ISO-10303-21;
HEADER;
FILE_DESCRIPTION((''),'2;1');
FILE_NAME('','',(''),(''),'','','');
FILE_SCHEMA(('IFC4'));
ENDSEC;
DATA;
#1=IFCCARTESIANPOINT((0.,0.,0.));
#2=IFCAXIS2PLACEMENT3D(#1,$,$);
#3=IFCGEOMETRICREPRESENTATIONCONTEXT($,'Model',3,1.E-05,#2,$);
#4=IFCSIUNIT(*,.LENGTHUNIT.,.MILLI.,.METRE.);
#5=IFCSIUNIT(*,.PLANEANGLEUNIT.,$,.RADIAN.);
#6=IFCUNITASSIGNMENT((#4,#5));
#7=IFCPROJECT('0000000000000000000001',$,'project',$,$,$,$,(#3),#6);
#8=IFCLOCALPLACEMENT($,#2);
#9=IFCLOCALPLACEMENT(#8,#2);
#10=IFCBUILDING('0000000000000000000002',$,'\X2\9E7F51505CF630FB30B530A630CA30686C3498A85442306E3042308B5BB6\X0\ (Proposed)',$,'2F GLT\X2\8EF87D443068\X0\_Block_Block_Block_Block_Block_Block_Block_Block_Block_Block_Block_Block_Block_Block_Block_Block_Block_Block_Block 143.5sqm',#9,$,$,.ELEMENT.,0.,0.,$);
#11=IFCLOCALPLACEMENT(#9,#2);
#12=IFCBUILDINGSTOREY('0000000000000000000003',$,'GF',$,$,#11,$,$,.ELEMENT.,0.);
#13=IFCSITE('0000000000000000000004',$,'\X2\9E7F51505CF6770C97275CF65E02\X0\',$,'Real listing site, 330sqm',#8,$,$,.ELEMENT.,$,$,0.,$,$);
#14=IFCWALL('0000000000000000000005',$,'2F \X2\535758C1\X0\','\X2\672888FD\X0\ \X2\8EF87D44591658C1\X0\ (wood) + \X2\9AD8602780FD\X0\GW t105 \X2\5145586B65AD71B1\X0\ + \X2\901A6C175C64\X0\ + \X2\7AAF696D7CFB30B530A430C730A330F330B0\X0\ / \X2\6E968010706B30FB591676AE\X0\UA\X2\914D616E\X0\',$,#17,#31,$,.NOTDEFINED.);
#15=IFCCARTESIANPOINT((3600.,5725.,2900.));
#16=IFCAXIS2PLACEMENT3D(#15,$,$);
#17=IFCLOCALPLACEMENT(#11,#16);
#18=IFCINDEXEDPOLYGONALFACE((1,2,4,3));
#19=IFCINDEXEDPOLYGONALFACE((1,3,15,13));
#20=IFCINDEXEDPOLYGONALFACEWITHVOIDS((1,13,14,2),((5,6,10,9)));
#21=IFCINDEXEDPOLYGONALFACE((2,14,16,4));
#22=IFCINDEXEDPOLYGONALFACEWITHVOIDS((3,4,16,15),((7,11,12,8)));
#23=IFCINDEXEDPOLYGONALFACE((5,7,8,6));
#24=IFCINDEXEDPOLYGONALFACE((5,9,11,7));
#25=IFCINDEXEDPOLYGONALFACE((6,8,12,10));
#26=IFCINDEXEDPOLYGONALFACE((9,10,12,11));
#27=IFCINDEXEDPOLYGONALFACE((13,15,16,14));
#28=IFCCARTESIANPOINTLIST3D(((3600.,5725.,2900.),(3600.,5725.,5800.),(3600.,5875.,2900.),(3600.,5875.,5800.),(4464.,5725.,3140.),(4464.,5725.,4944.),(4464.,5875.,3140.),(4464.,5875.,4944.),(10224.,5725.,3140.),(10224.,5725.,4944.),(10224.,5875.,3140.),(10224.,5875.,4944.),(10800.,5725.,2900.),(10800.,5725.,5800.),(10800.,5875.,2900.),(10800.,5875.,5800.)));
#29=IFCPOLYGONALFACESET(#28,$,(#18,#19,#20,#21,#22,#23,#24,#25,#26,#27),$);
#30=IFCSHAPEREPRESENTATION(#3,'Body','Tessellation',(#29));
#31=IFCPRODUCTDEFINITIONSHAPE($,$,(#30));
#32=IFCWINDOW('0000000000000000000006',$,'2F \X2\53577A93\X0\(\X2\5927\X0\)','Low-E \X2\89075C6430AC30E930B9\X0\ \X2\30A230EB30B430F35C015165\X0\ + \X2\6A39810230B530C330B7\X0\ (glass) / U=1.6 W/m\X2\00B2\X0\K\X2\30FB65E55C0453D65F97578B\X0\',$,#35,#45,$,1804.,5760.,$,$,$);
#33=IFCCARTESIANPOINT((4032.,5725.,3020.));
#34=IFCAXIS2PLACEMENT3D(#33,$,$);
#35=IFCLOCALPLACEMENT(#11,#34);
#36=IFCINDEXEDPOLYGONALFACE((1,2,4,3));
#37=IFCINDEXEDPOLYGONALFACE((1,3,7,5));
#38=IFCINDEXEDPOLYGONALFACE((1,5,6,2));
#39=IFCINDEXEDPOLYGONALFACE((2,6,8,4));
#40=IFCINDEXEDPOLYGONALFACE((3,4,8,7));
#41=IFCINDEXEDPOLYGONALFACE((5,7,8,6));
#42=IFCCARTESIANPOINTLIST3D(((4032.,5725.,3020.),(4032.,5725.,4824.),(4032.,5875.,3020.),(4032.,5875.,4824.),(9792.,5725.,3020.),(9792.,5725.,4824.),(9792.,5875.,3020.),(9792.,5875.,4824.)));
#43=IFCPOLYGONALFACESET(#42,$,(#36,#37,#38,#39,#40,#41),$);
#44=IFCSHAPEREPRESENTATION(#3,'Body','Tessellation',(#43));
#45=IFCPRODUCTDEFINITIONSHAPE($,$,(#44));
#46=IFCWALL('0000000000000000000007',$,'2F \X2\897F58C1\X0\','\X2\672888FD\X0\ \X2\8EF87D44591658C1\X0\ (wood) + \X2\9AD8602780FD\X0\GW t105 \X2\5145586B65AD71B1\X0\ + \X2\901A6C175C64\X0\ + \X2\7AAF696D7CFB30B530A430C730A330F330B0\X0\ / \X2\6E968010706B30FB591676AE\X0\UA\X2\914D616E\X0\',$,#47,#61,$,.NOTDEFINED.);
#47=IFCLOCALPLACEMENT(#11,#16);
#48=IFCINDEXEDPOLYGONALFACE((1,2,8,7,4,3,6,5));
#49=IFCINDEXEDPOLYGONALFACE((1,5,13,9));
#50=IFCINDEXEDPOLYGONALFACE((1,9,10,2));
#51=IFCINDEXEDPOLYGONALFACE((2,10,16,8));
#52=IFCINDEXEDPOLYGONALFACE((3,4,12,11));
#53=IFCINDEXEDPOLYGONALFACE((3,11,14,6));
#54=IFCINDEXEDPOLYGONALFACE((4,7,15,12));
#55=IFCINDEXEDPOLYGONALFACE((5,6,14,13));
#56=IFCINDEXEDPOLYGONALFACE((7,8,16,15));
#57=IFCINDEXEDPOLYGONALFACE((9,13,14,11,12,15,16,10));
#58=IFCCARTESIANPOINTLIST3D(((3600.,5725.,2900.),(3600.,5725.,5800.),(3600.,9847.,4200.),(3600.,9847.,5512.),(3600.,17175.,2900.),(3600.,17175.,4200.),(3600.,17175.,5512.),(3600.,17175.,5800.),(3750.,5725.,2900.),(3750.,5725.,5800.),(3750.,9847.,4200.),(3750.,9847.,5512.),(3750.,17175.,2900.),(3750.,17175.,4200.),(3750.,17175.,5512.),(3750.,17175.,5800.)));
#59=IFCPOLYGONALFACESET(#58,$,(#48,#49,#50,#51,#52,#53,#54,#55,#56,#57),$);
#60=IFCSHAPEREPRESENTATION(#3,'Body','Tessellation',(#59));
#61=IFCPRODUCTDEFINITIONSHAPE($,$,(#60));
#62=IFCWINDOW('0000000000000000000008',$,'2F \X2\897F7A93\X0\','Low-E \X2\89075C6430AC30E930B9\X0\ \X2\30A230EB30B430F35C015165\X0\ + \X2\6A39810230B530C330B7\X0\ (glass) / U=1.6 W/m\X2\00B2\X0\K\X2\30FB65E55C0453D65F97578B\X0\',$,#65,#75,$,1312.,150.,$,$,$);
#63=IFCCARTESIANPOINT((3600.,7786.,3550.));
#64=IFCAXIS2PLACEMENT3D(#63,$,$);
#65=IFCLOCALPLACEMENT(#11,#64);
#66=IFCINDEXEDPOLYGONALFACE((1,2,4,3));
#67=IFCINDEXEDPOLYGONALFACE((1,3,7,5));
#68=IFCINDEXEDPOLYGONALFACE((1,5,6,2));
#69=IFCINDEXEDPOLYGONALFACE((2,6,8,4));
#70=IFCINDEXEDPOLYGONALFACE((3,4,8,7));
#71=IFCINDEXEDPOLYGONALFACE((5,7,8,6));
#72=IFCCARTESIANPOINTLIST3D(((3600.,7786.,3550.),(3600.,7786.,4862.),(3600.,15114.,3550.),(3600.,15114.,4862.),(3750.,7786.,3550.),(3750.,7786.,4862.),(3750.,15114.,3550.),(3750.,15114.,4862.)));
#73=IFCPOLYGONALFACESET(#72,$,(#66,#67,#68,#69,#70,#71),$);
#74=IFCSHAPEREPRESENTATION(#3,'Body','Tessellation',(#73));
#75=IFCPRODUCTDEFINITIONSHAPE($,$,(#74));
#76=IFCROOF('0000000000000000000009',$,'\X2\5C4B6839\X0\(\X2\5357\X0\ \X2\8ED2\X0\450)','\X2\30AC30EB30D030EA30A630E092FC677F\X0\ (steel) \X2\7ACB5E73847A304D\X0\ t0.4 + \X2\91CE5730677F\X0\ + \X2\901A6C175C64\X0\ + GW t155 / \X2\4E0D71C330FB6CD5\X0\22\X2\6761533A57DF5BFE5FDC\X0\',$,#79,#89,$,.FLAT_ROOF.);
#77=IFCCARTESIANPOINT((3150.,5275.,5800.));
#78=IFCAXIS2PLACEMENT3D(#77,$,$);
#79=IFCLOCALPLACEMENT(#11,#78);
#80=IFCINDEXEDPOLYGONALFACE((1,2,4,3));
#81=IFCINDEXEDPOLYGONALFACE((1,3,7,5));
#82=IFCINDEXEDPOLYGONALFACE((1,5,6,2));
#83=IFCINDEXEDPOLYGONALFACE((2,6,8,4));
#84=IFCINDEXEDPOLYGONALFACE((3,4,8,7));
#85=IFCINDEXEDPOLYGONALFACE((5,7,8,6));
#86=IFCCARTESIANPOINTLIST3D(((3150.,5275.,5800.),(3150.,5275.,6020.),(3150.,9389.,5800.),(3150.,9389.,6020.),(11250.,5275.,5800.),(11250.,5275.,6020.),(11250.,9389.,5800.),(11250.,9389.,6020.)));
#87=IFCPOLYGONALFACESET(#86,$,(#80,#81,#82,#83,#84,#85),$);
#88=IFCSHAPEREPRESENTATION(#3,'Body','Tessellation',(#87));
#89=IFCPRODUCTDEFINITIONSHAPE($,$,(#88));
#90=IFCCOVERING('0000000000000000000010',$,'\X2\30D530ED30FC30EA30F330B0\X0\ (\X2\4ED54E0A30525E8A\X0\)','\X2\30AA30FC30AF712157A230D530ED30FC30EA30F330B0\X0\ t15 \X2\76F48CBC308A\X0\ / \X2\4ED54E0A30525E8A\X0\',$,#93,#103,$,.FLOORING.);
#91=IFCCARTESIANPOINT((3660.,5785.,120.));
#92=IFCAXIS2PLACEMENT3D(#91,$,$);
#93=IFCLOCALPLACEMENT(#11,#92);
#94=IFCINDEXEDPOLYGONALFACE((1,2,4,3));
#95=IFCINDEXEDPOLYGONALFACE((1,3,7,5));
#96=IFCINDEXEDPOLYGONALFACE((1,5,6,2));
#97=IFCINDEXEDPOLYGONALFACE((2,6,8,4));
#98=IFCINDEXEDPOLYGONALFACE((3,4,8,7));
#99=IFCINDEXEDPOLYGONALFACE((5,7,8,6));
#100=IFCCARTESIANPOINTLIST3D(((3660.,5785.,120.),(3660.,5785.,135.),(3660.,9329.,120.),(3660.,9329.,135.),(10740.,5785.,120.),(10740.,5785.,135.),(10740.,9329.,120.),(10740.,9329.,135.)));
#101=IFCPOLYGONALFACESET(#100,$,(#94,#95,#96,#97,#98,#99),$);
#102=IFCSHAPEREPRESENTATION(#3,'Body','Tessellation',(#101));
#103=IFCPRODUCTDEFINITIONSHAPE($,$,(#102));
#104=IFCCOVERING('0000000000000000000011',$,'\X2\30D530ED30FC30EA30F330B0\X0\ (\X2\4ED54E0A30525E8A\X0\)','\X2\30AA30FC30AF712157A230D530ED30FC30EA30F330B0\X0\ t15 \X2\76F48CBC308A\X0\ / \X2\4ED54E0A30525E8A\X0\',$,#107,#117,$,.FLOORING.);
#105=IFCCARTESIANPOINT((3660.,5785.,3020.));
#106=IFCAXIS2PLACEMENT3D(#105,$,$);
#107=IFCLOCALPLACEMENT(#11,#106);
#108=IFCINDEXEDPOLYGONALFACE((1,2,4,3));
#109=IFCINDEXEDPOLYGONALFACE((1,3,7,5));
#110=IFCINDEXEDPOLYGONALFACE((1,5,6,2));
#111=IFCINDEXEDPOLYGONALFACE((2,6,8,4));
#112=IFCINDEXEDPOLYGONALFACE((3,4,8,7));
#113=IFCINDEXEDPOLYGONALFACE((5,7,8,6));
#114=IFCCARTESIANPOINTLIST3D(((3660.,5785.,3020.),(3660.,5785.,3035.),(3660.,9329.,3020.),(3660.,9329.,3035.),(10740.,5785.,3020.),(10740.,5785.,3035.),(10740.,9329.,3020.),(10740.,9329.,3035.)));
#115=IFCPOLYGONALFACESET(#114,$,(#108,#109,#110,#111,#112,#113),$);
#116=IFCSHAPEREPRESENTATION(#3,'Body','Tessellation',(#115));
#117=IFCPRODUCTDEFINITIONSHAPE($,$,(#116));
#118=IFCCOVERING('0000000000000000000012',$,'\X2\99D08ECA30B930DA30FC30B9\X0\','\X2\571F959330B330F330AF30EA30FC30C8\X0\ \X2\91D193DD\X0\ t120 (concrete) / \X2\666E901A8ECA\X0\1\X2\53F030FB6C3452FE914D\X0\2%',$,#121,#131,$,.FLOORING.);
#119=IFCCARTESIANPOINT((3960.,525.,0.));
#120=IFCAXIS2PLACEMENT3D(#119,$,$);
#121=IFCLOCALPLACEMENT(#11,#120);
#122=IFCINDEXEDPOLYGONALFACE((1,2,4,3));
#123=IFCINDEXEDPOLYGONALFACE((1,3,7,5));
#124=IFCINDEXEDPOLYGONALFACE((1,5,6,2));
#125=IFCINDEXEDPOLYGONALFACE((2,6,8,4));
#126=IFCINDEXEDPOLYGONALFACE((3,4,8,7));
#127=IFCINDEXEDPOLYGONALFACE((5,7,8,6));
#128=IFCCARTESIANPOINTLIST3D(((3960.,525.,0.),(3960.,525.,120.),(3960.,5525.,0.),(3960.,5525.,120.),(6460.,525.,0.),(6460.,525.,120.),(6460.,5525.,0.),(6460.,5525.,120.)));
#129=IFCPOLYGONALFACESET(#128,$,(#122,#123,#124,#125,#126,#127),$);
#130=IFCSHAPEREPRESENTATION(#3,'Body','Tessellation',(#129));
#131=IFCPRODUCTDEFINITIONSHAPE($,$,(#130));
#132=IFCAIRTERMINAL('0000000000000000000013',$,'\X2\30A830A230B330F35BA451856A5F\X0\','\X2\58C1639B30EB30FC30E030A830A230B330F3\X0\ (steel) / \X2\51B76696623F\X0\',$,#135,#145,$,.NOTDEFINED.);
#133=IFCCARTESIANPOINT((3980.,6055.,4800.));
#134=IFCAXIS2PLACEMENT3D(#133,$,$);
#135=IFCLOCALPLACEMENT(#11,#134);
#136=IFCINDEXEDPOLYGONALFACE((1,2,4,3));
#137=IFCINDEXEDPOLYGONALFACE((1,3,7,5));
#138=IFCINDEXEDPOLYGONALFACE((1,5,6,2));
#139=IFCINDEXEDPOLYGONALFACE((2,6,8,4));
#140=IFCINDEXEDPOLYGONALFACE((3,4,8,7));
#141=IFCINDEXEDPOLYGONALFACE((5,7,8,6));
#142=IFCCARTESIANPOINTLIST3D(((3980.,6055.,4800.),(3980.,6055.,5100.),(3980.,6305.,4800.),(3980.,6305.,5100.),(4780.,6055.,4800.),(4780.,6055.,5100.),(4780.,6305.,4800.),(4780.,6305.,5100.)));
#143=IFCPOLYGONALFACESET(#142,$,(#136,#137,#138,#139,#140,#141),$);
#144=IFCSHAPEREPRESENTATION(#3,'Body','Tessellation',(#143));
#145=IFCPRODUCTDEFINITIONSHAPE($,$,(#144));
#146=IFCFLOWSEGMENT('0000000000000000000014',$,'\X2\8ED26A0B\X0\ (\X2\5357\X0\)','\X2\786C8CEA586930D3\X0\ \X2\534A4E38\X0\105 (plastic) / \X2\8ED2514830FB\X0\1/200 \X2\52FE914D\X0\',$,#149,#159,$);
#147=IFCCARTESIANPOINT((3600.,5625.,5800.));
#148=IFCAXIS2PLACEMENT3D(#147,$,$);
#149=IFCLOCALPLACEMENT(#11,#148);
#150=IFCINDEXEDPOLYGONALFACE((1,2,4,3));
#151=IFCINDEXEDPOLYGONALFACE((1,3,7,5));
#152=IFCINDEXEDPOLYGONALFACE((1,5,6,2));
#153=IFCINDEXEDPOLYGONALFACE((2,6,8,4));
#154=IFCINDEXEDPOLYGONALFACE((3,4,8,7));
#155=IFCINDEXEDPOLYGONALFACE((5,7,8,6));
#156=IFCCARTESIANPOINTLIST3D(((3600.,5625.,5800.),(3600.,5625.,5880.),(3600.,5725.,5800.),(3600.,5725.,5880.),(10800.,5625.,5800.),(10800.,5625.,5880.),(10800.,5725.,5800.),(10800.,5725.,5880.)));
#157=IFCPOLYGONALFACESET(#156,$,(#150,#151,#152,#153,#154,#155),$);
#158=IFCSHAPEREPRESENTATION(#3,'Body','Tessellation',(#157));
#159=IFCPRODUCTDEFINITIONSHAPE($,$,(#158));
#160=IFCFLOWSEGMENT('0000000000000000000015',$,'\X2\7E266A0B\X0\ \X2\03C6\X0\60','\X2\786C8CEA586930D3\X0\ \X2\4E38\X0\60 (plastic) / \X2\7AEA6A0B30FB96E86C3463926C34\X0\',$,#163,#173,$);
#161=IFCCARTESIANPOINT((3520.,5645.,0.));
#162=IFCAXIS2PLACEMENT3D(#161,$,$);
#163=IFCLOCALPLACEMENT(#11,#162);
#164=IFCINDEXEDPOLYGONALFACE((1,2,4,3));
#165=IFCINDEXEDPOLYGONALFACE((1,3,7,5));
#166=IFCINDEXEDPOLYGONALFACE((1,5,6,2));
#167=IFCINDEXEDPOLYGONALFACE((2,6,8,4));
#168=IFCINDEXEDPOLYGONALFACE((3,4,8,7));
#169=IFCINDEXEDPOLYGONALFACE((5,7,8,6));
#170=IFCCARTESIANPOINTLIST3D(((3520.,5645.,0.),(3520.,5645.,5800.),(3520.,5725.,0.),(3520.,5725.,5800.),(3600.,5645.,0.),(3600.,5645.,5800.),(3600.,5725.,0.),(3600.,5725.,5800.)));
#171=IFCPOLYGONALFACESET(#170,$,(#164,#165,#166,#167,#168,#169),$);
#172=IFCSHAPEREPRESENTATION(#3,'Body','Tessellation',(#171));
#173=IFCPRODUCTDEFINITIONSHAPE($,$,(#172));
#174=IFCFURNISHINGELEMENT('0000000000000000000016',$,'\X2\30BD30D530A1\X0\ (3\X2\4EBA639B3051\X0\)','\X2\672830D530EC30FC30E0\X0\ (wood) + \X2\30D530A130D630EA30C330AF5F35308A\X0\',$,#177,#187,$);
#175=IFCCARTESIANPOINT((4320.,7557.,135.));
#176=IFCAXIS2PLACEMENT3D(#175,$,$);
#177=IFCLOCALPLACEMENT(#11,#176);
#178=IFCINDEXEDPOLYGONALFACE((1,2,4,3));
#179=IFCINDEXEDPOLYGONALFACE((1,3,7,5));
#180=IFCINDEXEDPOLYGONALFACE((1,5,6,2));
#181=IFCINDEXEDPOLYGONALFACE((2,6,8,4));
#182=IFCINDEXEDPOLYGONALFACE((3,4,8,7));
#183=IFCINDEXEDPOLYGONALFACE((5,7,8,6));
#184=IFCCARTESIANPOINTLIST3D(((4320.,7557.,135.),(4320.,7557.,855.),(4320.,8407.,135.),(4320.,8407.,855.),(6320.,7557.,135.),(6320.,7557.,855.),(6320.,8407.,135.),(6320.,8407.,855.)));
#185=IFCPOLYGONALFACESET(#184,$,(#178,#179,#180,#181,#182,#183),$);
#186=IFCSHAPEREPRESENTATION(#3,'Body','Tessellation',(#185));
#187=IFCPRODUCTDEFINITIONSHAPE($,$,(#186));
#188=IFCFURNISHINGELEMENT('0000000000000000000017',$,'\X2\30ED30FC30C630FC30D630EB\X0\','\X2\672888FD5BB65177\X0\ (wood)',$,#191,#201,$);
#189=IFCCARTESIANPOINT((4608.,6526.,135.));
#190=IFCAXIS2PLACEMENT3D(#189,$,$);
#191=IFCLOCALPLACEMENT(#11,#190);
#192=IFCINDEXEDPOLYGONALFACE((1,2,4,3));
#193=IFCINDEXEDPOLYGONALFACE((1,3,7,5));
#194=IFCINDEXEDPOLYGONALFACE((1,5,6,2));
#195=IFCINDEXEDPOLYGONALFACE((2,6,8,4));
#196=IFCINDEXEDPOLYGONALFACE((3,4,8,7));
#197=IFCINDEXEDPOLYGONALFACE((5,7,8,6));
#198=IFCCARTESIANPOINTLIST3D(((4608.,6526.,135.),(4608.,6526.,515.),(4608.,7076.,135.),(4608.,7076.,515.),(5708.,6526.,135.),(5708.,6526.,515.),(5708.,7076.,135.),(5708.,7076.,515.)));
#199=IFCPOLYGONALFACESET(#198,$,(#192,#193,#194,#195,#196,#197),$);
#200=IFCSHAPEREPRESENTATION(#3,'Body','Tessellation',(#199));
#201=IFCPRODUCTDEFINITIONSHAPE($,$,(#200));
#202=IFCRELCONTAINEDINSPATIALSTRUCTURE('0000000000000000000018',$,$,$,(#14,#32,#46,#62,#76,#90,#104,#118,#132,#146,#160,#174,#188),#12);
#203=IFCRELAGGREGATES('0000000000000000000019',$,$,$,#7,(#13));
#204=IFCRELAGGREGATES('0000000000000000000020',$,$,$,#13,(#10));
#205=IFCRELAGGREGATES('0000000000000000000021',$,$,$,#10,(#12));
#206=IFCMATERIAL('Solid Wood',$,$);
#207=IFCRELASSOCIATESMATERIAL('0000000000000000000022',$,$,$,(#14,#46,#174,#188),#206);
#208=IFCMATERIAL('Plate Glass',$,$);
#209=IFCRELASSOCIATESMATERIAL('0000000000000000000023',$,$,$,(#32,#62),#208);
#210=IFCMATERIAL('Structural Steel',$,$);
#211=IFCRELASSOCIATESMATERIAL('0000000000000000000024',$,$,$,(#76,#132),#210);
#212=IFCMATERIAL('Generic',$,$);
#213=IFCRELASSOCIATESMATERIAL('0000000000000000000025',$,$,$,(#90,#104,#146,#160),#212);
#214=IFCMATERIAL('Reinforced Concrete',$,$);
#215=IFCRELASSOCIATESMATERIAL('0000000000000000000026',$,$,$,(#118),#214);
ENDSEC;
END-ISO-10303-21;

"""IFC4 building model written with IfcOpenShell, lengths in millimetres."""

from ifc_helpers import new_model, si_unit, frame, frame_2d, origin, place, context, project, spatial, rectangle, extrude, material, element, fill, save


model = new_model("IFC4")

# Units and contexts
model_context = context("Model", 3, precision=1e-05, world=origin())
ifc_project = project(units=[si_unit("LENGTHUNIT", "METRE", prefix="MILLI"), si_unit("PLANEANGLEUNIT", "RADIAN")], contexts=[model_context])

# Site, building, storey
site_placement = place(None, origin())
site = spatial("IfcSite", under=ifc_project, at=site_placement, Name="鹿児島県霧島市", ObjectType="Real listing site, 330sqm", CompositionType="ELEMENT", RefElevation=0.0)
building_placement = place(site_placement, origin())
building = spatial("IfcBuilding", under=site, at=building_placement, Name="鹿児島・サウナと水風呂のある家 (Proposed)", ObjectType="2F GLT軸組と_Block_Block_Block_Block_Block_Block_Block_Block_Block_Block_Block_Block_Block_Block_Block_Block_Block_Block_Block 143.5sqm", CompositionType="ELEMENT", ElevationOfRefHeight=0.0, ElevationOfTerrain=0.0)
storey_placement = place(building_placement, origin())
storey = spatial("IfcBuildingStorey", under=building, at=storey_placement, Name="GF", CompositionType="ELEMENT", Elevation=0.0)

# Shared definitions
ifc_material_1 = material(Name="Solid Wood")

# Shared definitions
ifc_material_2 = material(Name="Reinforced Concrete")

# Shared definitions
ifc_material_3 = material(Name="Plate Glass")

# Walls, openings, windows
wall_1_placement = place(storey_placement, frame((3600.0, 5725.0, 2900.0)))
wall_1 = element("IfcWall", 1, at=wall_1_placement, inside=storey, material=ifc_material_1, Name="2F 南壁", Description="木製 軸組外壁 (wood) + 高性能GW t105 充填断熱 + 通気層 + 窯業系サイディング / 準耐火・外皮UA配慮", PredefinedType="NOTDEFINED", context=model_context, shape_type="SweptSolid", body=[
    extrude(rectangle(XDim=7200.0, YDim=150.0, at=frame_2d((3600.0, 75.0))), frame((3600.0, 5725.0, 2900.0)), (0.0, 0.0, 1.0), 2900.0),
])
opening_1_placement = place(storey_placement, frame((4032.0, 5725.0, 3020.0)))
opening_1 = element("IfcOpeningElement", 2, at=opening_1_placement, cuts=wall_1, PredefinedType="NOTDEFINED", context=model_context, shape_type="SweptSolid", body=[
    extrude(rectangle(XDim=5760.0, YDim=150.0, at=frame_2d((2880.0, 75.0))), frame((4032.0, 5725.0, 3020.0)), (0.0, 0.0, 1.0), 1804.0),
])
window_1_placement = place(storey_placement, frame((4032.0, 5725.0, 3020.0)))
window_1 = element("IfcWindow", 3, at=window_1_placement, inside=storey, material=ifc_material_3, Name="2F 南窓(大)", Description="Low-E 複層ガラス アルゴン封入 + 樹脂サッシ (glass) / U=1.6 W/m²K・日射取得型", OverallHeight=1804.0, OverallWidth=5760.0, context=model_context, shape_type="SweptSolid", body=[
    extrude(rectangle(XDim=5760.0, YDim=150.0, at=frame_2d((2880.0, 75.0))), frame((4032.0, 5725.0, 3020.0)), (0.0, 0.0, 1.0), 1804.0),
])
fill(opening_1, window_1)
wall_2_placement = place(storey_placement, frame((3600.0, 5725.0, 2900.0)))
wall_2 = element("IfcWall", 4, at=wall_2_placement, inside=storey, material=ifc_material_1, Name="2F 西壁", Description="木製 軸組外壁 (wood) + 高性能GW t105 充填断熱 + 通気層 + 窯業系サイディング / 準耐火・外皮UA配慮", PredefinedType="NOTDEFINED", context=model_context, shape_type="SweptSolid", body=[
    extrude(rectangle(XDim=150.0, YDim=11450.0, at=frame_2d((75.0, 5725.0))), frame((3600.0, 5725.0, 2900.0)), (0.0, 0.0, 1.0), 2900.0),
])
opening_2_placement = place(storey_placement, frame((3600.0, 7786.0, 3550.0)))
opening_2 = element("IfcOpeningElement", 5, at=opening_2_placement, cuts=wall_2, PredefinedType="NOTDEFINED", context=model_context, shape_type="SweptSolid", body=[
    extrude(rectangle(XDim=150.0, YDim=7328.0, at=frame_2d((75.0, 3664.0))), frame((3600.0, 7786.0, 3550.0)), (0.0, 0.0, 1.0), 1312.0),
])
window_2_placement = place(storey_placement, frame((3600.0, 7786.0, 3550.0)))
window_2 = element("IfcWindow", 6, at=window_2_placement, inside=storey, material=ifc_material_3, Name="2F 西窓", Description="Low-E 複層ガラス アルゴン封入 + 樹脂サッシ (glass) / U=1.6 W/m²K・日射取得型", OverallHeight=1312.0, OverallWidth=150.0, context=model_context, shape_type="SweptSolid", body=[
    extrude(rectangle(XDim=150.0, YDim=7328.0, at=frame_2d((75.0, 3664.0))), frame((3600.0, 7786.0, 3550.0)), (0.0, 0.0, 1.0), 1312.0),
])
fill(opening_2, window_2)

# Roof
ifc_material_4 = material(Name="Structural Steel")
for number, where, name in (
    (7, (3150.0, 5275.0, 5800.0), "屋根(南 軒450)"),
):
    element("IfcRoof", number, at=place(storey_placement, frame(where)), inside=storey, material=ifc_material_4, Name=name, Description="ガルバリウム鋼板 (steel) 立平葺き t0.4 + 野地板 + 通気層 + GW t155 / 不燃・法22条区域対応", PredefinedType="FLAT_ROOF", context=model_context, shape_type="SweptSolid", body=[
        extrude(rectangle(XDim=8100.0, YDim=4114.0, at=frame_2d((4050.0, 2057.0))), frame((3150.0, 5275.0, 5800.0)), (0.0, 0.0, 1.0), 220.0),
    ])

# Coverings
ifc_material_5 = material(Name="Generic")
covering_1_placement = place(storey_placement, frame((3660.0, 5785.0, 120.0)))
element("IfcCovering", 8, at=covering_1_placement, inside=storey, material=ifc_material_5, Name="フローリング (仕上げ床)", Description="オーク無垢フローリング t15 直貼り / 仕上げ床", PredefinedType="FLOORING", context=model_context, shape_type="SweptSolid", body=[
    extrude(rectangle(XDim=7080.0, YDim=3544.0, at=frame_2d((3540.0, 1772.0))), frame((3660.0, 5785.0, 120.0)), (0.0, 0.0, 1.0), 15.0),
])
covering_2_placement = place(storey_placement, frame((3660.0, 5785.0, 3020.0)))
element("IfcCovering", 9, at=covering_2_placement, inside=storey, material=ifc_material_5, Name="フローリング (仕上げ床)", Description="オーク無垢フローリング t15 直貼り / 仕上げ床", PredefinedType="FLOORING", context=model_context, shape_type="SweptSolid", body=[
    extrude(rectangle(XDim=7080.0, YDim=3544.0, at=frame_2d((3540.0, 1772.0))), frame((3660.0, 5785.0, 3020.0)), (0.0, 0.0, 1.0), 15.0),
])
covering_3_placement = place(storey_placement, frame((3960.0, 525.0, 0.0)))
element("IfcCovering", 10, at=covering_3_placement, inside=storey, material=ifc_material_2, Name="駐車スペース", Description="土間コンクリート 金鏝 t120 (concrete) / 普通車1台・水勾配2%", PredefinedType="FLOORING", context=model_context, shape_type="SweptSolid", body=[
    extrude(rectangle(XDim=2500.0, YDim=5000.0, at=frame_2d((1250.0, 2500.0))), frame((3960.0, 525.0, 0.0)), (0.0, 0.0, 1.0), 120.0),
])

# Air terminal
air_terminal_placement = place(storey_placement, frame((3980.0, 6055.0, 4800.0)))
element("IfcAirTerminal", 11, at=air_terminal_placement, inside=storey, material=ifc_material_4, Name="エアコン室内機", Description="壁掛ルームエアコン (steel) / 冷暖房", PredefinedType="NOTDEFINED", context=model_context, shape_type="SweptSolid", body=[
    extrude(rectangle(XDim=800.0, YDim=250.0, at=frame_2d((400.0, 125.0))), frame((3980.0, 6055.0, 4800.0)), (0.0, 0.0, 1.0), 300.0),
])

# Flow segments
flow_segment_1_placement = place(storey_placement, frame((3600.0, 5625.0, 5800.0)))
element("IfcFlowSegment", 12, at=flow_segment_1_placement, inside=storey, material=ifc_material_5, Name="軒樋 (南)", Description="硬質塩ビ 半丸105 (plastic) / 軒先・1/200 勾配", context=model_context, shape_type="SweptSolid", body=[
    extrude(rectangle(XDim=7200.0, YDim=100.0, at=frame_2d((3600.0, 50.0))), frame((3600.0, 5625.0, 5800.0)), (0.0, 0.0, 1.0), 80.0),
])
flow_segment_2_placement = place(storey_placement, frame((3520.0, 5645.0, 0.0)))
element("IfcFlowSegment", 13, at=flow_segment_2_placement, inside=storey, material=ifc_material_5, Name="縦樋 φ60", Description="硬質塩ビ 丸60 (plastic) / 竪樋・雨水排水", context=model_context, shape_type="SweptSolid", body=[
    extrude(rectangle(XDim=80.0, YDim=80.0, at=frame_2d((40.0, 40.0))), frame((3520.0, 5645.0, 0.0)), (0.0, 0.0, 1.0), 5800.0),
])

# Furnishing elements
furnishing_1_placement = place(storey_placement, frame((4320.0, 7557.0, 135.0)))
element("IfcFurnishingElement", 14, at=furnishing_1_placement, inside=storey, material=ifc_material_1, Name="ソファ (3人掛け)", Description="木フレーム (wood) + ファブリック張り", context=model_context, shape_type="SweptSolid", body=[
    extrude(rectangle(XDim=2000.0, YDim=850.0, at=frame_2d((1000.0, 425.0))), frame((4320.0, 7557.0, 135.0)), (0.0, 0.0, 1.0), 720.0),
])
furnishing_2_placement = place(storey_placement, frame((4608.0, 6526.0, 135.0)))
element("IfcFurnishingElement", 15, at=furnishing_2_placement, inside=storey, material=ifc_material_1, Name="ローテーブル", Description="木製家具 (wood)", context=model_context, shape_type="SweptSolid", body=[
    extrude(rectangle(XDim=1100.0, YDim=550.0, at=frame_2d((550.0, 275.0))), frame((4608.0, 6526.0, 135.0)), (0.0, 0.0, 1.0), 380.0),
])

save(model, "model.ifc")
